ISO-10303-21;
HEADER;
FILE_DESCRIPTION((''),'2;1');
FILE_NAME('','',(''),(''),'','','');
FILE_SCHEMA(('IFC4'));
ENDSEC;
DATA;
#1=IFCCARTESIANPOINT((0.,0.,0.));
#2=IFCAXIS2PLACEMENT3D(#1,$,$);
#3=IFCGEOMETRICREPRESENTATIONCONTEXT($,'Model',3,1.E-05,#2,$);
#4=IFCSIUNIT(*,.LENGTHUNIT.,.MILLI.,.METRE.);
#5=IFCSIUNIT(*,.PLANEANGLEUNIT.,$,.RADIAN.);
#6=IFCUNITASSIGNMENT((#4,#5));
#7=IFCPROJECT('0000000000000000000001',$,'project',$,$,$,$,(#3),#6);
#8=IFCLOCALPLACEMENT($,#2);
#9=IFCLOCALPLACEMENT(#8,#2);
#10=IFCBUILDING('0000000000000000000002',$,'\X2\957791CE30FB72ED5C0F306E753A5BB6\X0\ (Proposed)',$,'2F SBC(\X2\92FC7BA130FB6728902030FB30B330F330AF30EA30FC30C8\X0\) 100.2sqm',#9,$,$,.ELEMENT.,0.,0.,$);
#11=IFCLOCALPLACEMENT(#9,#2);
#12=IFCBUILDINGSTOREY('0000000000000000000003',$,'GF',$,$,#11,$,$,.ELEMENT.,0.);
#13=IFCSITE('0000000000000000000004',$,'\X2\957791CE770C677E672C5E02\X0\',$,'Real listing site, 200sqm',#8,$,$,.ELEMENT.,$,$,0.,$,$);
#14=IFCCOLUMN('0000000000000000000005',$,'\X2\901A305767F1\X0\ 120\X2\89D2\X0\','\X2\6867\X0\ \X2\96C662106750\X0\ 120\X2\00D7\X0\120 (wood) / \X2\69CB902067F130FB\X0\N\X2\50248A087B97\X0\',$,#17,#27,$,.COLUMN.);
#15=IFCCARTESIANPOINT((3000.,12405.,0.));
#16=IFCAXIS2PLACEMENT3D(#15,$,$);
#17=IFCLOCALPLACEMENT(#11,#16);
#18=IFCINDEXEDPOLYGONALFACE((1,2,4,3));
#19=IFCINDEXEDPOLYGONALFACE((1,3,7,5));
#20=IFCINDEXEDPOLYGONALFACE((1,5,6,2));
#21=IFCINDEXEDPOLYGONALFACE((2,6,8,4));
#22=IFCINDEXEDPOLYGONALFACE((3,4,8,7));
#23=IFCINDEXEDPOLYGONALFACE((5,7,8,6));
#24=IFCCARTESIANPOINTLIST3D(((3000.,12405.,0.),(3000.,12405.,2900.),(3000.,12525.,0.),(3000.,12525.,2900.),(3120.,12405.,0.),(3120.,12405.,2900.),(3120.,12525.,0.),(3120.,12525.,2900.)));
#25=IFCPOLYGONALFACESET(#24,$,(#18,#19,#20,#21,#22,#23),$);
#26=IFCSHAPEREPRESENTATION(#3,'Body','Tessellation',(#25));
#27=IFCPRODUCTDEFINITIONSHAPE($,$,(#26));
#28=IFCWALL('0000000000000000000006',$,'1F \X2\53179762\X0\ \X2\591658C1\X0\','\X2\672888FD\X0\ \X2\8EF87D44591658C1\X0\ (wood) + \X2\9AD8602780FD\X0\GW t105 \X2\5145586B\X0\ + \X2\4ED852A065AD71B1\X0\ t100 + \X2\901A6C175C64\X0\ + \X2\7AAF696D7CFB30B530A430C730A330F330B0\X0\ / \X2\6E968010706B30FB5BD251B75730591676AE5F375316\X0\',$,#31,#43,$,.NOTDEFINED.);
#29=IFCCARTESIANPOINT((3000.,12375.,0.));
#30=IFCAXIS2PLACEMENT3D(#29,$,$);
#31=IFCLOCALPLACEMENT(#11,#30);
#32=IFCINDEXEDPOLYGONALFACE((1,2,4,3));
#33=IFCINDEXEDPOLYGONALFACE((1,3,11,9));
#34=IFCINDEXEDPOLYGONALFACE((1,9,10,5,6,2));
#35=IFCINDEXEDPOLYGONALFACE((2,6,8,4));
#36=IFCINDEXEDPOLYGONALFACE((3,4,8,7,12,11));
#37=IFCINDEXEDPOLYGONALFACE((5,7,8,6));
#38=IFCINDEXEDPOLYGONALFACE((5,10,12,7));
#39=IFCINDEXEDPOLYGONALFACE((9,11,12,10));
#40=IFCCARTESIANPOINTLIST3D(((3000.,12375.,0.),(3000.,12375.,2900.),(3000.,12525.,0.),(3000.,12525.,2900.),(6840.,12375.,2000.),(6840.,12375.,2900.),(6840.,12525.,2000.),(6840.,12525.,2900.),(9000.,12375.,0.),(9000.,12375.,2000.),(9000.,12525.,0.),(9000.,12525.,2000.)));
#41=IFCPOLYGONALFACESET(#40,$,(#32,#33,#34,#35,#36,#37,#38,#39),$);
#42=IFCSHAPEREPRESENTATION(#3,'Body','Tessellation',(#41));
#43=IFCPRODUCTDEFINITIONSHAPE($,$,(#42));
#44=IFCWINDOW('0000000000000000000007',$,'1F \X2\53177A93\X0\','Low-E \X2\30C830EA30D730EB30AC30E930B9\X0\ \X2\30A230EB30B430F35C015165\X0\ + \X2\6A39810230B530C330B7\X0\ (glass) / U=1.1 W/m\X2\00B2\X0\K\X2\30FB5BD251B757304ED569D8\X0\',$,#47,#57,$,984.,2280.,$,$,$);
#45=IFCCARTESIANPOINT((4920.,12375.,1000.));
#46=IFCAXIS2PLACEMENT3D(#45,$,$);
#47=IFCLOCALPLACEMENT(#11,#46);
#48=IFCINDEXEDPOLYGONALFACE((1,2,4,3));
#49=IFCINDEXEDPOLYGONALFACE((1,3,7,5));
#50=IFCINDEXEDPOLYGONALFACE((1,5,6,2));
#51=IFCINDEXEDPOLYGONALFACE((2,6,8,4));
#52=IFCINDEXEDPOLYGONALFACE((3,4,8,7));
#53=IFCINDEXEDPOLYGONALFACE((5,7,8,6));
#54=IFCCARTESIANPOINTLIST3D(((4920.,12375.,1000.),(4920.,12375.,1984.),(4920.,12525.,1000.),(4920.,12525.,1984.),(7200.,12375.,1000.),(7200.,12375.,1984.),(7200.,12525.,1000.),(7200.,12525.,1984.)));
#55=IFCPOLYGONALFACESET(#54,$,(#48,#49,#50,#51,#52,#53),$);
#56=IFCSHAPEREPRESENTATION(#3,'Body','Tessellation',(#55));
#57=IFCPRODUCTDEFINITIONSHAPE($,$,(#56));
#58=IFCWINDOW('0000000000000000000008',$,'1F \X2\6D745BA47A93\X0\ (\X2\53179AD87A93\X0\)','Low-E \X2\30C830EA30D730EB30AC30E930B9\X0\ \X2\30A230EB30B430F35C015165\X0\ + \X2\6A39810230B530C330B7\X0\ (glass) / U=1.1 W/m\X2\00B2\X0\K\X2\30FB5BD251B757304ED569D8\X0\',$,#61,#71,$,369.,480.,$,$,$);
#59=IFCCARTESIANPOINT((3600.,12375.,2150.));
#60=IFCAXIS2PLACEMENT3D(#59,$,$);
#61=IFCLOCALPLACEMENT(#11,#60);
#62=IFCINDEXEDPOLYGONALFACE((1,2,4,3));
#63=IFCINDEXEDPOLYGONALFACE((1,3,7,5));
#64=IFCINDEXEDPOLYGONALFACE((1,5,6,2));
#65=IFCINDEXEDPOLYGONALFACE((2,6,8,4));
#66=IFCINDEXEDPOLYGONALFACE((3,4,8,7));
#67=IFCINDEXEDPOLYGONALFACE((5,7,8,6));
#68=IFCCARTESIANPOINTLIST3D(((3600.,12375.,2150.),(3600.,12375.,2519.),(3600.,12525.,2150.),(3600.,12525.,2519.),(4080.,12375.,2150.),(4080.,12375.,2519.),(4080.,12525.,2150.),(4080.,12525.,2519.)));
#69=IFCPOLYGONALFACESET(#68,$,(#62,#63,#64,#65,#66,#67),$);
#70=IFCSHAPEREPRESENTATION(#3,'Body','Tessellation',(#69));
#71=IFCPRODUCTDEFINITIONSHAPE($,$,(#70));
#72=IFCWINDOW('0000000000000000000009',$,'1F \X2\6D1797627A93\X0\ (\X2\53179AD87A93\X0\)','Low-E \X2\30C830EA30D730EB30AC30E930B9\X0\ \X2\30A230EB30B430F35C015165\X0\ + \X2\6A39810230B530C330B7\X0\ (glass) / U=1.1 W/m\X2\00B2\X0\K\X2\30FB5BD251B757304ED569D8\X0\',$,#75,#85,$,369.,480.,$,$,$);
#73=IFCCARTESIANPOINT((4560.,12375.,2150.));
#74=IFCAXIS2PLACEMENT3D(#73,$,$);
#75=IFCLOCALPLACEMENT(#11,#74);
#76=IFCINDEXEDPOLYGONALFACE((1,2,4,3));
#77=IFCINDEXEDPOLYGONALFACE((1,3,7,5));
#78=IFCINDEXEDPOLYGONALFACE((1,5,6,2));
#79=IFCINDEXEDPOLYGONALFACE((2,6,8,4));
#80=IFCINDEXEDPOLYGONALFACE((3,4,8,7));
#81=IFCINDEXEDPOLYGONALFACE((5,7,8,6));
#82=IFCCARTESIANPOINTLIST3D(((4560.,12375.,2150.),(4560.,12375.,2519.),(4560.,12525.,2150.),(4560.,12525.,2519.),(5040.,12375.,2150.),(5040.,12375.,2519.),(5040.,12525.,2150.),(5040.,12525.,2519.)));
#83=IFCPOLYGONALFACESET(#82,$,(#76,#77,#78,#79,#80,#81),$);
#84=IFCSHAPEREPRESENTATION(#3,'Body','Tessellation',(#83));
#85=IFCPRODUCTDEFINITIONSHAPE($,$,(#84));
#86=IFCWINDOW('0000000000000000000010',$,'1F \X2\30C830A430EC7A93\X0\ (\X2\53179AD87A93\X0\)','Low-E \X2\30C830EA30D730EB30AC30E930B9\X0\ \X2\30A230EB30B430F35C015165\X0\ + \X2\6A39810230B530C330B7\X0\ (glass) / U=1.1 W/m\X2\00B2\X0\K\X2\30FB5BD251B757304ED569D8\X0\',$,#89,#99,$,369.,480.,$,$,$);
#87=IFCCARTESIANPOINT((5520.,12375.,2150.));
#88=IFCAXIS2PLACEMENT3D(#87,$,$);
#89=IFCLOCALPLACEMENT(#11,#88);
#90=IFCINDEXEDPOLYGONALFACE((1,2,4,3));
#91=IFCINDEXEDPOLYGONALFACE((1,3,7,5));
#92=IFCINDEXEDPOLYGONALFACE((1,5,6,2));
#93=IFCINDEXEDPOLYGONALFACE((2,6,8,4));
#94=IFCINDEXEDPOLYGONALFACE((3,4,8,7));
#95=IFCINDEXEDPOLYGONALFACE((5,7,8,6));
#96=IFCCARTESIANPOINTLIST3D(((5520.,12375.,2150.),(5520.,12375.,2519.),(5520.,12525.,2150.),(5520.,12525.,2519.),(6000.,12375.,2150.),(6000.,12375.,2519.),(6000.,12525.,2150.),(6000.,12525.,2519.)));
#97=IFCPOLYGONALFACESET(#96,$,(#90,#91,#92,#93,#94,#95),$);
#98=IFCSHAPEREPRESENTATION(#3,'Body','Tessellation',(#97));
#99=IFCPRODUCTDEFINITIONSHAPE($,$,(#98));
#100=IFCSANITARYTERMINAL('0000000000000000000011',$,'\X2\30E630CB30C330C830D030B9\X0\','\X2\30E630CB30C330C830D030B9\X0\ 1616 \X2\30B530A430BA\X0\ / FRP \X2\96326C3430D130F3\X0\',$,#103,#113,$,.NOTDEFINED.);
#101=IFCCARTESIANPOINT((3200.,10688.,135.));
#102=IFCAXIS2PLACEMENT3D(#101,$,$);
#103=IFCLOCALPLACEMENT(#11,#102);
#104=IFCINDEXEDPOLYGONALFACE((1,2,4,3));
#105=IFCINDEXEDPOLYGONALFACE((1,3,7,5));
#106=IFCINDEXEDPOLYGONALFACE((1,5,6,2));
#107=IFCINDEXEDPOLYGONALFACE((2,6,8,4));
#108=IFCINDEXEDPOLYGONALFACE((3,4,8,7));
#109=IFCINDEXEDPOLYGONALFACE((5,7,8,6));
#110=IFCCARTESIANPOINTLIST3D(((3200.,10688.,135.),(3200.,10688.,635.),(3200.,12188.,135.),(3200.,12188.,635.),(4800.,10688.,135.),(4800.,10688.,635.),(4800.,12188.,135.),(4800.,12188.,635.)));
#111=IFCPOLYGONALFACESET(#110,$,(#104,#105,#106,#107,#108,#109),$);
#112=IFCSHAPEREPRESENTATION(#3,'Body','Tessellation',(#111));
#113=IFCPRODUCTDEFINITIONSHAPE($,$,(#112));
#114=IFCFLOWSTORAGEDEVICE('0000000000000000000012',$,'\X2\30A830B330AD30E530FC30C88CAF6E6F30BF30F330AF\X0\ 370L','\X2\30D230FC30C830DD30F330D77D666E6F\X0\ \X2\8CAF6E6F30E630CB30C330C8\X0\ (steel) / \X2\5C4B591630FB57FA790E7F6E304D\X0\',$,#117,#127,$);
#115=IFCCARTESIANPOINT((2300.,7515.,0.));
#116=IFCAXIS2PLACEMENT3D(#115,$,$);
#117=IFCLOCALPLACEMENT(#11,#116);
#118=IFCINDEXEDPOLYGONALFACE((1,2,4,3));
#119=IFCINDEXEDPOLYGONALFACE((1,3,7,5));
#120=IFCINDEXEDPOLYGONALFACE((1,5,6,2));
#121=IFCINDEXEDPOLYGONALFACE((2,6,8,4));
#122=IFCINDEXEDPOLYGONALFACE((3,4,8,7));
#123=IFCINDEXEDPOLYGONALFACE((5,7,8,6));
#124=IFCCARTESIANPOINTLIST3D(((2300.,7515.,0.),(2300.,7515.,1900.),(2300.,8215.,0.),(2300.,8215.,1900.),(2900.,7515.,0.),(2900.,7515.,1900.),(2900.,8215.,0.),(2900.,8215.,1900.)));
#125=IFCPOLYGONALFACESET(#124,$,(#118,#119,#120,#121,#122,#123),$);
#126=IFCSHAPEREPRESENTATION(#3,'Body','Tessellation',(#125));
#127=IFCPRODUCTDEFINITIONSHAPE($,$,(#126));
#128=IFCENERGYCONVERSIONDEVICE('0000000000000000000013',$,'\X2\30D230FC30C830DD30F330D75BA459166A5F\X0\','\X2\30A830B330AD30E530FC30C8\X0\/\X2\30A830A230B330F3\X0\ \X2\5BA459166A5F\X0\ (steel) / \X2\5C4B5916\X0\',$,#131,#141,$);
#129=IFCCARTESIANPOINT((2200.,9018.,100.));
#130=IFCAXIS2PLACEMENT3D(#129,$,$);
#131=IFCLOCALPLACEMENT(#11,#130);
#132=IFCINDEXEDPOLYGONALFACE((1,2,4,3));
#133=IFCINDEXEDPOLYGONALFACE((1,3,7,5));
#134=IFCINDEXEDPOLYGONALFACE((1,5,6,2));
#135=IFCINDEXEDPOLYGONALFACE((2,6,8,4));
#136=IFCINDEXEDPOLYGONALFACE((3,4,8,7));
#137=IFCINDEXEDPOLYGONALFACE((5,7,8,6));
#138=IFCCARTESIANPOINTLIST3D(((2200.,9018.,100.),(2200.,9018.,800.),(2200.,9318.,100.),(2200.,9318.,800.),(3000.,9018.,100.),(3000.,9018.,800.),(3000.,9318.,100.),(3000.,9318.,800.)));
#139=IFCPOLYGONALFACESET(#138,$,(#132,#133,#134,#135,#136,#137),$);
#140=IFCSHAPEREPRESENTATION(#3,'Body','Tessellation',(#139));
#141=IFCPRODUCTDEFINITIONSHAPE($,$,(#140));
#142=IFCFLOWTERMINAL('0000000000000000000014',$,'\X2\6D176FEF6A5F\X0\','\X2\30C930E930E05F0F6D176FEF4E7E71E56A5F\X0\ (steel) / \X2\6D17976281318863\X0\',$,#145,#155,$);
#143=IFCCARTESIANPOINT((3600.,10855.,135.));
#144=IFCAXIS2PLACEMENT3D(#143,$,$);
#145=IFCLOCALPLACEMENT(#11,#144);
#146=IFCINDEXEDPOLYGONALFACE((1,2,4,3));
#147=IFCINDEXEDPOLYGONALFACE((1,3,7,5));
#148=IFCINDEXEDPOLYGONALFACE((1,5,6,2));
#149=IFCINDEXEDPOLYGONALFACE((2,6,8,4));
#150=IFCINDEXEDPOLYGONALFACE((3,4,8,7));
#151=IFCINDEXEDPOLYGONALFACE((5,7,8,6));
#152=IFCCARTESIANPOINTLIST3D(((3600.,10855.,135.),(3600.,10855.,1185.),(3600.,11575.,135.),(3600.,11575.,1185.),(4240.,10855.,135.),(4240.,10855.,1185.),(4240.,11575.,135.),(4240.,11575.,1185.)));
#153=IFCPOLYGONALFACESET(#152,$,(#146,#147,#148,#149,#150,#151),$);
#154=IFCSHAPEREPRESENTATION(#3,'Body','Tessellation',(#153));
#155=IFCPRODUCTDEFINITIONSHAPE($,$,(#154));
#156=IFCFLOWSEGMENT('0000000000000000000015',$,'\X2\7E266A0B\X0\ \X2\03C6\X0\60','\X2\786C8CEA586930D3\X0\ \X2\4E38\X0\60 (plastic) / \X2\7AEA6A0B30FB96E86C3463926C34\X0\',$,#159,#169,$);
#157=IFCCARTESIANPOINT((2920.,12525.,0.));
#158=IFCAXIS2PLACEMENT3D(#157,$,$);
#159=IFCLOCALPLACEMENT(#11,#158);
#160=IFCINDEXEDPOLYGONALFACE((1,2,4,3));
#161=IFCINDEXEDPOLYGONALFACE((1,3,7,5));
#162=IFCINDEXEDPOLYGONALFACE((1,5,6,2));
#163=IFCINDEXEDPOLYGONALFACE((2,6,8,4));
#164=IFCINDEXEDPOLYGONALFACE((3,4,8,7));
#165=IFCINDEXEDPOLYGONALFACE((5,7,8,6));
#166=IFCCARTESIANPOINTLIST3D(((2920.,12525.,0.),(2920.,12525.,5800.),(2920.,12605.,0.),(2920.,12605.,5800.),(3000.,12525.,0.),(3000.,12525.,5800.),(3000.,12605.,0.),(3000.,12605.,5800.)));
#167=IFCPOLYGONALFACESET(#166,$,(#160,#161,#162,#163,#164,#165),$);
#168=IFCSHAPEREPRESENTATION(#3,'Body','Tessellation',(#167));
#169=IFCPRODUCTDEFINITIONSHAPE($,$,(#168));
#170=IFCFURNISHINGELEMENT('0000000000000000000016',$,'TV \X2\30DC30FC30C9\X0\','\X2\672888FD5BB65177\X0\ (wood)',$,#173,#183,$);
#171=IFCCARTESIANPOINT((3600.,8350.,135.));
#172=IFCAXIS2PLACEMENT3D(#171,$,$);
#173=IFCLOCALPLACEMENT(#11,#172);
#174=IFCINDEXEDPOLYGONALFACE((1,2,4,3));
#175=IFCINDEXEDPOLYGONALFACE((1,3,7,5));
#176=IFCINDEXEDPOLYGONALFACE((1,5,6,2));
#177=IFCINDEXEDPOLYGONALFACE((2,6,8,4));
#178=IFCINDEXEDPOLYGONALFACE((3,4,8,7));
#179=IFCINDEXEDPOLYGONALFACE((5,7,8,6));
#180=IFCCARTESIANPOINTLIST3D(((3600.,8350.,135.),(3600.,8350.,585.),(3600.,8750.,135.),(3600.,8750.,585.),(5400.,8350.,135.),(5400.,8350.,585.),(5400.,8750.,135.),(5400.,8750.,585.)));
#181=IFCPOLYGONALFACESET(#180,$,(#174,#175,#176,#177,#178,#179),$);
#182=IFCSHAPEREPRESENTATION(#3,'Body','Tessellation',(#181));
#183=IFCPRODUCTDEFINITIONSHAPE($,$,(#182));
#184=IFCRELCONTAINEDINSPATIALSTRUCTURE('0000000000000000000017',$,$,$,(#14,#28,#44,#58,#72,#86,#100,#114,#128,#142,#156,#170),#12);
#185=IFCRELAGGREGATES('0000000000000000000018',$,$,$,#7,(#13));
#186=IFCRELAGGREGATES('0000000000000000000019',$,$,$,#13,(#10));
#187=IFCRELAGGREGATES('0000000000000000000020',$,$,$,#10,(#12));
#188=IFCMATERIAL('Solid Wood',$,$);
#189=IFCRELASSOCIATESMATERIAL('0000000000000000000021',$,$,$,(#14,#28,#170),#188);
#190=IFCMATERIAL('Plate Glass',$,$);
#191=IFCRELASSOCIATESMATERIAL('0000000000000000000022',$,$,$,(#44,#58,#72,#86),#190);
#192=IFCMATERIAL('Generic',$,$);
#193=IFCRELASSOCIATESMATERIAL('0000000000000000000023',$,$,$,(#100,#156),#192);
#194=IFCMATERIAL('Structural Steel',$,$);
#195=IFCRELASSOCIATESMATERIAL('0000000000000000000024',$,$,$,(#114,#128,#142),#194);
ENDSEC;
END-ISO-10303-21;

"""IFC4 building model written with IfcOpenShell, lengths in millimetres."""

from ifc_helpers import new_model, si_unit, frame, frame_2d, origin, place, context, project, spatial, rectangle, extrude, material, element, fill, save


model = new_model("IFC4")

# Units and contexts
model_context = context("Model", 3, precision=1e-05, world=origin())
ifc_project = project(units=[si_unit("LENGTHUNIT", "METRE", prefix="MILLI"), si_unit("PLANEANGLEUNIT", "RADIAN")], contexts=[model_context])

# Site, building, storey
site_placement = place(None, origin())
site = spatial("IfcSite", under=ifc_project, at=site_placement, Name="長野県松本市", ObjectType="Real listing site, 200sqm", CompositionType="ELEMENT", RefElevation=0.0)
building_placement = place(site_placement, origin())
building = spatial("IfcBuilding", under=site, at=building_placement, Name="長野・狭小の町家 (Proposed)", ObjectType="2F SBC(鋼管・木造・コンクリート) 100.2sqm", CompositionType="ELEMENT", ElevationOfRefHeight=0.0, ElevationOfTerrain=0.0)
storey_placement = place(building_placement, origin())
storey = spatial("IfcBuildingStorey", under=building, at=storey_placement, Name="GF", CompositionType="ELEMENT", Elevation=0.0)

# Column
ifc_material_1 = material(Name="Solid Wood")
column_1_placement = place(storey_placement, frame((3000.0, 12405.0, 0.0)))
element("IfcColumn", 1, at=column_1_placement, inside=storey, material=ifc_material_1, Name="通し柱 120角", Description="桧 集成材 120×120 (wood) / 構造柱・N値計算", PredefinedType="COLUMN", context=model_context, shape_type="SweptSolid", body=[
    extrude(rectangle(XDim=120.0, YDim=120.0, at=frame_2d((60.0, 60.0))), frame((3000.0, 12405.0, 0.0)), (0.0, 0.0, 1.0), 2900.0),
])

# Wall, openings, windows
wall_1_placement = place(storey_placement, frame((3000.0, 12375.0, 0.0)))
wall_1 = element("IfcWall", 2, at=wall_1_placement, inside=storey, material=ifc_material_1, Name="1F 北面 外壁", Description="木製 軸組外壁 (wood) + 高性能GW t105 充填 + 付加断熱 t100 + 通気層 + 窯業系サイディング / 準耐火・寒冷地外皮強化", PredefinedType="NOTDEFINED", context=model_context, shape_type="SweptSolid", body=[
    extrude(rectangle(XDim=6000.0, YDim=150.0, at=frame_2d((3000.0, 75.0))), frame((3000.0, 12375.0, 0.0)), (0.0, 0.0, 1.0), 2900.0),
])
opening_1_placement = place(storey_placement, frame((4920.0, 12375.0, 1000.0)))
opening_1 = element("IfcOpeningElement", 3, at=opening_1_placement, cuts=wall_1, PredefinedType="NOTDEFINED", context=model_context, shape_type="SweptSolid", body=[
    extrude(rectangle(XDim=2280.0, YDim=150.0, at=frame_2d((1140.0, 75.0))), frame((4920.0, 12375.0, 1000.0)), (0.0, 0.0, 1.0), 984.0),
])
opening_2_placement = place(storey_placement, frame((3600.0, 12375.0, 2150.0)))
opening_2 = element("IfcOpeningElement", 4, at=opening_2_placement, cuts=wall_1, PredefinedType="NOTDEFINED", context=model_context, shape_type="SweptSolid", body=[
    extrude(rectangle(XDim=480.0, YDim=150.0, at=frame_2d((240.0, 75.0))), frame((3600.0, 12375.0, 2150.0)), (0.0, 0.0, 1.0), 369.0),
])
opening_3_placement = place(storey_placement, frame((4560.0, 12375.0, 2150.0)))
opening_3 = element("IfcOpeningElement", 5, at=opening_3_placement, cuts=wall_1, PredefinedType="NOTDEFINED", context=model_context, shape_type="SweptSolid", body=[
    extrude(rectangle(XDim=480.0, YDim=150.0, at=frame_2d((240.0, 75.0))), frame((4560.0, 12375.0, 2150.0)), (0.0, 0.0, 1.0), 369.0),
])
opening_4_placement = place(storey_placement, frame((5520.0, 12375.0, 2150.0)))
opening_4 = element("IfcOpeningElement", 6, at=opening_4_placement, cuts=wall_1, PredefinedType="NOTDEFINED", context=model_context, shape_type="SweptSolid", body=[
    extrude(rectangle(XDim=480.0, YDim=150.0, at=frame_2d((240.0, 75.0))), frame((5520.0, 12375.0, 2150.0)), (0.0, 0.0, 1.0), 369.0),
])
ifc_material_2 = material(Name="Plate Glass")
window_1_placement = place(storey_placement, frame((4920.0, 12375.0, 1000.0)))
window_1 = element("IfcWindow", 7, at=window_1_placement, inside=storey, material=ifc_material_2, Name="1F 北窓", Description="Low-E トリプルガラス アルゴン封入 + 樹脂サッシ (glass) / U=1.1 W/m²K・寒冷地仕様", OverallHeight=984.0, OverallWidth=2280.0, context=model_context, shape_type="SweptSolid", body=[
    extrude(rectangle(XDim=2280.0, YDim=150.0, at=frame_2d((1140.0, 75.0))), frame((4920.0, 12375.0, 1000.0)), (0.0, 0.0, 1.0), 984.0),
])
fill(opening_1, window_1)
window_2_placement = place(storey_placement, frame((3600.0, 12375.0, 2150.0)))
window_2 = element("IfcWindow", 8, at=window_2_placement, inside=storey, material=ifc_material_2, Name="1F 浴室窓 (北高窓)", Description="Low-E トリプルガラス アルゴン封入 + 樹脂サッシ (glass) / U=1.1 W/m²K・寒冷地仕様", OverallHeight=369.0, OverallWidth=480.0, context=model_context, shape_type="SweptSolid", body=[
    extrude(rectangle(XDim=480.0, YDim=150.0, at=frame_2d((240.0, 75.0))), frame((3600.0, 12375.0, 2150.0)), (0.0, 0.0, 1.0), 369.0),
])
fill(opening_2, window_2)
window_3_placement = place(storey_placement, frame((4560.0, 12375.0, 2150.0)))
window_3 = element("IfcWindow", 9, at=window_3_placement, inside=storey, material=ifc_material_2, Name="1F 洗面窓 (北高窓)", Description="Low-E トリプルガラス アルゴン封入 + 樹脂サッシ (glass) / U=1.1 W/m²K・寒冷地仕様", OverallHeight=369.0, OverallWidth=480.0, context=model_context, shape_type="SweptSolid", body=[
    extrude(rectangle(XDim=480.0, YDim=150.0, at=frame_2d((240.0, 75.0))), frame((4560.0, 12375.0, 2150.0)), (0.0, 0.0, 1.0), 369.0),
])
fill(opening_3, window_3)
window_4_placement = place(storey_placement, frame((5520.0, 12375.0, 2150.0)))
window_4 = element("IfcWindow", 10, at=window_4_placement, inside=storey, material=ifc_material_2, Name="1F トイレ窓 (北高窓)", Description="Low-E トリプルガラス アルゴン封入 + 樹脂サッシ (glass) / U=1.1 W/m²K・寒冷地仕様", OverallHeight=369.0, OverallWidth=480.0, context=model_context, shape_type="SweptSolid", body=[
    extrude(rectangle(XDim=480.0, YDim=150.0, at=frame_2d((240.0, 75.0))), frame((5520.0, 12375.0, 2150.0)), (0.0, 0.0, 1.0), 369.0),
])
fill(opening_4, window_4)

# Sanitary terminal
ifc_material_3 = material(Name="Generic")
sanitary_terminal_placement = place(storey_placement, frame((3200.0, 10688.0, 135.0)))
element("IfcSanitaryTerminal", 11, at=sanitary_terminal_placement, inside=storey, material=ifc_material_3, Name="ユニットバス", Description="ユニットバス 1616 サイズ / FRP 防水パン", PredefinedType="NOTDEFINED", context=model_context, shape_type="SweptSolid", body=[
    extrude(rectangle(XDim=1600.0, YDim=1500.0, at=frame_2d((800.0, 750.0))), frame((3200.0, 10688.0, 135.0)), (0.0, 0.0, 1.0), 500.0),
])

# Flow storage device
ifc_material_4 = material(Name="Structural Steel")
flow_storage_device_placement = place(storey_placement, frame((2300.0, 7515.0, 0.0)))
element("IfcFlowStorageDevice", 12, at=flow_storage_device_placement, inside=storey, material=ifc_material_4, Name="エコキュート貯湯タンク 370L", Description="ヒートポンプ給湯 貯湯ユニット (steel) / 屋外・基礎置き", context=model_context, shape_type="SweptSolid", body=[
    extrude(rectangle(XDim=600.0, YDim=700.0, at=frame_2d((300.0, 350.0))), frame((2300.0, 7515.0, 0.0)), (0.0, 0.0, 1.0), 1900.0),
])

# Energy conversion device
energy_conversion_device_placement = place(storey_placement, frame((2200.0, 9018.0, 100.0)))
element("IfcEnergyConversionDevice", 13, at=energy_conversion_device_placement, inside=storey, material=ifc_material_4, Name="ヒートポンプ室外機", Description="エコキュート/エアコン 室外機 (steel) / 屋外", context=model_context, shape_type="SweptSolid", body=[
    extrude(rectangle(XDim=800.0, YDim=300.0, at=frame_2d((400.0, 150.0))), frame((2200.0, 9018.0, 100.0)), (0.0, 0.0, 1.0), 700.0),
])

# Flow terminal
flow_terminal_placement = place(storey_placement, frame((3600.0, 10855.0, 135.0)))
element("IfcFlowTerminal", 14, at=flow_terminal_placement, inside=storey, material=ifc_material_4, Name="洗濯機", Description="ドラム式洗濯乾燥機 (steel) / 洗面脱衣", context=model_context, shape_type="SweptSolid", body=[
    extrude(rectangle(XDim=640.0, YDim=720.0, at=frame_2d((320.0, 360.0))), frame((3600.0, 10855.0, 135.0)), (0.0, 0.0, 1.0), 1050.0),
])

# Flow segment
flow_segment_placement = place(storey_placement, frame((2920.0, 12525.0, 0.0)))
element("IfcFlowSegment", 15, at=flow_segment_placement, inside=storey, material=ifc_material_3, Name="縦樋 φ60", Description="硬質塩ビ 丸60 (plastic) / 竪樋・雨水排水", context=model_context, shape_type="SweptSolid", body=[
    extrude(rectangle(XDim=80.0, YDim=80.0, at=frame_2d((40.0, 40.0))), frame((2920.0, 12525.0, 0.0)), (0.0, 0.0, 1.0), 5800.0),
])

# Furnishing element
furnishing_placement = place(storey_placement, frame((3600.0, 8350.0, 135.0)))
element("IfcFurnishingElement", 16, at=furnishing_placement, inside=storey, material=ifc_material_1, Name="TV ボード", Description="木製家具 (wood)", context=model_context, shape_type="SweptSolid", body=[
    extrude(rectangle(XDim=1800.0, YDim=400.0, at=frame_2d((900.0, 200.0))), frame((3600.0, 8350.0, 135.0)), (0.0, 0.0, 1.0), 450.0),
])

save(model, "model.ifc")
